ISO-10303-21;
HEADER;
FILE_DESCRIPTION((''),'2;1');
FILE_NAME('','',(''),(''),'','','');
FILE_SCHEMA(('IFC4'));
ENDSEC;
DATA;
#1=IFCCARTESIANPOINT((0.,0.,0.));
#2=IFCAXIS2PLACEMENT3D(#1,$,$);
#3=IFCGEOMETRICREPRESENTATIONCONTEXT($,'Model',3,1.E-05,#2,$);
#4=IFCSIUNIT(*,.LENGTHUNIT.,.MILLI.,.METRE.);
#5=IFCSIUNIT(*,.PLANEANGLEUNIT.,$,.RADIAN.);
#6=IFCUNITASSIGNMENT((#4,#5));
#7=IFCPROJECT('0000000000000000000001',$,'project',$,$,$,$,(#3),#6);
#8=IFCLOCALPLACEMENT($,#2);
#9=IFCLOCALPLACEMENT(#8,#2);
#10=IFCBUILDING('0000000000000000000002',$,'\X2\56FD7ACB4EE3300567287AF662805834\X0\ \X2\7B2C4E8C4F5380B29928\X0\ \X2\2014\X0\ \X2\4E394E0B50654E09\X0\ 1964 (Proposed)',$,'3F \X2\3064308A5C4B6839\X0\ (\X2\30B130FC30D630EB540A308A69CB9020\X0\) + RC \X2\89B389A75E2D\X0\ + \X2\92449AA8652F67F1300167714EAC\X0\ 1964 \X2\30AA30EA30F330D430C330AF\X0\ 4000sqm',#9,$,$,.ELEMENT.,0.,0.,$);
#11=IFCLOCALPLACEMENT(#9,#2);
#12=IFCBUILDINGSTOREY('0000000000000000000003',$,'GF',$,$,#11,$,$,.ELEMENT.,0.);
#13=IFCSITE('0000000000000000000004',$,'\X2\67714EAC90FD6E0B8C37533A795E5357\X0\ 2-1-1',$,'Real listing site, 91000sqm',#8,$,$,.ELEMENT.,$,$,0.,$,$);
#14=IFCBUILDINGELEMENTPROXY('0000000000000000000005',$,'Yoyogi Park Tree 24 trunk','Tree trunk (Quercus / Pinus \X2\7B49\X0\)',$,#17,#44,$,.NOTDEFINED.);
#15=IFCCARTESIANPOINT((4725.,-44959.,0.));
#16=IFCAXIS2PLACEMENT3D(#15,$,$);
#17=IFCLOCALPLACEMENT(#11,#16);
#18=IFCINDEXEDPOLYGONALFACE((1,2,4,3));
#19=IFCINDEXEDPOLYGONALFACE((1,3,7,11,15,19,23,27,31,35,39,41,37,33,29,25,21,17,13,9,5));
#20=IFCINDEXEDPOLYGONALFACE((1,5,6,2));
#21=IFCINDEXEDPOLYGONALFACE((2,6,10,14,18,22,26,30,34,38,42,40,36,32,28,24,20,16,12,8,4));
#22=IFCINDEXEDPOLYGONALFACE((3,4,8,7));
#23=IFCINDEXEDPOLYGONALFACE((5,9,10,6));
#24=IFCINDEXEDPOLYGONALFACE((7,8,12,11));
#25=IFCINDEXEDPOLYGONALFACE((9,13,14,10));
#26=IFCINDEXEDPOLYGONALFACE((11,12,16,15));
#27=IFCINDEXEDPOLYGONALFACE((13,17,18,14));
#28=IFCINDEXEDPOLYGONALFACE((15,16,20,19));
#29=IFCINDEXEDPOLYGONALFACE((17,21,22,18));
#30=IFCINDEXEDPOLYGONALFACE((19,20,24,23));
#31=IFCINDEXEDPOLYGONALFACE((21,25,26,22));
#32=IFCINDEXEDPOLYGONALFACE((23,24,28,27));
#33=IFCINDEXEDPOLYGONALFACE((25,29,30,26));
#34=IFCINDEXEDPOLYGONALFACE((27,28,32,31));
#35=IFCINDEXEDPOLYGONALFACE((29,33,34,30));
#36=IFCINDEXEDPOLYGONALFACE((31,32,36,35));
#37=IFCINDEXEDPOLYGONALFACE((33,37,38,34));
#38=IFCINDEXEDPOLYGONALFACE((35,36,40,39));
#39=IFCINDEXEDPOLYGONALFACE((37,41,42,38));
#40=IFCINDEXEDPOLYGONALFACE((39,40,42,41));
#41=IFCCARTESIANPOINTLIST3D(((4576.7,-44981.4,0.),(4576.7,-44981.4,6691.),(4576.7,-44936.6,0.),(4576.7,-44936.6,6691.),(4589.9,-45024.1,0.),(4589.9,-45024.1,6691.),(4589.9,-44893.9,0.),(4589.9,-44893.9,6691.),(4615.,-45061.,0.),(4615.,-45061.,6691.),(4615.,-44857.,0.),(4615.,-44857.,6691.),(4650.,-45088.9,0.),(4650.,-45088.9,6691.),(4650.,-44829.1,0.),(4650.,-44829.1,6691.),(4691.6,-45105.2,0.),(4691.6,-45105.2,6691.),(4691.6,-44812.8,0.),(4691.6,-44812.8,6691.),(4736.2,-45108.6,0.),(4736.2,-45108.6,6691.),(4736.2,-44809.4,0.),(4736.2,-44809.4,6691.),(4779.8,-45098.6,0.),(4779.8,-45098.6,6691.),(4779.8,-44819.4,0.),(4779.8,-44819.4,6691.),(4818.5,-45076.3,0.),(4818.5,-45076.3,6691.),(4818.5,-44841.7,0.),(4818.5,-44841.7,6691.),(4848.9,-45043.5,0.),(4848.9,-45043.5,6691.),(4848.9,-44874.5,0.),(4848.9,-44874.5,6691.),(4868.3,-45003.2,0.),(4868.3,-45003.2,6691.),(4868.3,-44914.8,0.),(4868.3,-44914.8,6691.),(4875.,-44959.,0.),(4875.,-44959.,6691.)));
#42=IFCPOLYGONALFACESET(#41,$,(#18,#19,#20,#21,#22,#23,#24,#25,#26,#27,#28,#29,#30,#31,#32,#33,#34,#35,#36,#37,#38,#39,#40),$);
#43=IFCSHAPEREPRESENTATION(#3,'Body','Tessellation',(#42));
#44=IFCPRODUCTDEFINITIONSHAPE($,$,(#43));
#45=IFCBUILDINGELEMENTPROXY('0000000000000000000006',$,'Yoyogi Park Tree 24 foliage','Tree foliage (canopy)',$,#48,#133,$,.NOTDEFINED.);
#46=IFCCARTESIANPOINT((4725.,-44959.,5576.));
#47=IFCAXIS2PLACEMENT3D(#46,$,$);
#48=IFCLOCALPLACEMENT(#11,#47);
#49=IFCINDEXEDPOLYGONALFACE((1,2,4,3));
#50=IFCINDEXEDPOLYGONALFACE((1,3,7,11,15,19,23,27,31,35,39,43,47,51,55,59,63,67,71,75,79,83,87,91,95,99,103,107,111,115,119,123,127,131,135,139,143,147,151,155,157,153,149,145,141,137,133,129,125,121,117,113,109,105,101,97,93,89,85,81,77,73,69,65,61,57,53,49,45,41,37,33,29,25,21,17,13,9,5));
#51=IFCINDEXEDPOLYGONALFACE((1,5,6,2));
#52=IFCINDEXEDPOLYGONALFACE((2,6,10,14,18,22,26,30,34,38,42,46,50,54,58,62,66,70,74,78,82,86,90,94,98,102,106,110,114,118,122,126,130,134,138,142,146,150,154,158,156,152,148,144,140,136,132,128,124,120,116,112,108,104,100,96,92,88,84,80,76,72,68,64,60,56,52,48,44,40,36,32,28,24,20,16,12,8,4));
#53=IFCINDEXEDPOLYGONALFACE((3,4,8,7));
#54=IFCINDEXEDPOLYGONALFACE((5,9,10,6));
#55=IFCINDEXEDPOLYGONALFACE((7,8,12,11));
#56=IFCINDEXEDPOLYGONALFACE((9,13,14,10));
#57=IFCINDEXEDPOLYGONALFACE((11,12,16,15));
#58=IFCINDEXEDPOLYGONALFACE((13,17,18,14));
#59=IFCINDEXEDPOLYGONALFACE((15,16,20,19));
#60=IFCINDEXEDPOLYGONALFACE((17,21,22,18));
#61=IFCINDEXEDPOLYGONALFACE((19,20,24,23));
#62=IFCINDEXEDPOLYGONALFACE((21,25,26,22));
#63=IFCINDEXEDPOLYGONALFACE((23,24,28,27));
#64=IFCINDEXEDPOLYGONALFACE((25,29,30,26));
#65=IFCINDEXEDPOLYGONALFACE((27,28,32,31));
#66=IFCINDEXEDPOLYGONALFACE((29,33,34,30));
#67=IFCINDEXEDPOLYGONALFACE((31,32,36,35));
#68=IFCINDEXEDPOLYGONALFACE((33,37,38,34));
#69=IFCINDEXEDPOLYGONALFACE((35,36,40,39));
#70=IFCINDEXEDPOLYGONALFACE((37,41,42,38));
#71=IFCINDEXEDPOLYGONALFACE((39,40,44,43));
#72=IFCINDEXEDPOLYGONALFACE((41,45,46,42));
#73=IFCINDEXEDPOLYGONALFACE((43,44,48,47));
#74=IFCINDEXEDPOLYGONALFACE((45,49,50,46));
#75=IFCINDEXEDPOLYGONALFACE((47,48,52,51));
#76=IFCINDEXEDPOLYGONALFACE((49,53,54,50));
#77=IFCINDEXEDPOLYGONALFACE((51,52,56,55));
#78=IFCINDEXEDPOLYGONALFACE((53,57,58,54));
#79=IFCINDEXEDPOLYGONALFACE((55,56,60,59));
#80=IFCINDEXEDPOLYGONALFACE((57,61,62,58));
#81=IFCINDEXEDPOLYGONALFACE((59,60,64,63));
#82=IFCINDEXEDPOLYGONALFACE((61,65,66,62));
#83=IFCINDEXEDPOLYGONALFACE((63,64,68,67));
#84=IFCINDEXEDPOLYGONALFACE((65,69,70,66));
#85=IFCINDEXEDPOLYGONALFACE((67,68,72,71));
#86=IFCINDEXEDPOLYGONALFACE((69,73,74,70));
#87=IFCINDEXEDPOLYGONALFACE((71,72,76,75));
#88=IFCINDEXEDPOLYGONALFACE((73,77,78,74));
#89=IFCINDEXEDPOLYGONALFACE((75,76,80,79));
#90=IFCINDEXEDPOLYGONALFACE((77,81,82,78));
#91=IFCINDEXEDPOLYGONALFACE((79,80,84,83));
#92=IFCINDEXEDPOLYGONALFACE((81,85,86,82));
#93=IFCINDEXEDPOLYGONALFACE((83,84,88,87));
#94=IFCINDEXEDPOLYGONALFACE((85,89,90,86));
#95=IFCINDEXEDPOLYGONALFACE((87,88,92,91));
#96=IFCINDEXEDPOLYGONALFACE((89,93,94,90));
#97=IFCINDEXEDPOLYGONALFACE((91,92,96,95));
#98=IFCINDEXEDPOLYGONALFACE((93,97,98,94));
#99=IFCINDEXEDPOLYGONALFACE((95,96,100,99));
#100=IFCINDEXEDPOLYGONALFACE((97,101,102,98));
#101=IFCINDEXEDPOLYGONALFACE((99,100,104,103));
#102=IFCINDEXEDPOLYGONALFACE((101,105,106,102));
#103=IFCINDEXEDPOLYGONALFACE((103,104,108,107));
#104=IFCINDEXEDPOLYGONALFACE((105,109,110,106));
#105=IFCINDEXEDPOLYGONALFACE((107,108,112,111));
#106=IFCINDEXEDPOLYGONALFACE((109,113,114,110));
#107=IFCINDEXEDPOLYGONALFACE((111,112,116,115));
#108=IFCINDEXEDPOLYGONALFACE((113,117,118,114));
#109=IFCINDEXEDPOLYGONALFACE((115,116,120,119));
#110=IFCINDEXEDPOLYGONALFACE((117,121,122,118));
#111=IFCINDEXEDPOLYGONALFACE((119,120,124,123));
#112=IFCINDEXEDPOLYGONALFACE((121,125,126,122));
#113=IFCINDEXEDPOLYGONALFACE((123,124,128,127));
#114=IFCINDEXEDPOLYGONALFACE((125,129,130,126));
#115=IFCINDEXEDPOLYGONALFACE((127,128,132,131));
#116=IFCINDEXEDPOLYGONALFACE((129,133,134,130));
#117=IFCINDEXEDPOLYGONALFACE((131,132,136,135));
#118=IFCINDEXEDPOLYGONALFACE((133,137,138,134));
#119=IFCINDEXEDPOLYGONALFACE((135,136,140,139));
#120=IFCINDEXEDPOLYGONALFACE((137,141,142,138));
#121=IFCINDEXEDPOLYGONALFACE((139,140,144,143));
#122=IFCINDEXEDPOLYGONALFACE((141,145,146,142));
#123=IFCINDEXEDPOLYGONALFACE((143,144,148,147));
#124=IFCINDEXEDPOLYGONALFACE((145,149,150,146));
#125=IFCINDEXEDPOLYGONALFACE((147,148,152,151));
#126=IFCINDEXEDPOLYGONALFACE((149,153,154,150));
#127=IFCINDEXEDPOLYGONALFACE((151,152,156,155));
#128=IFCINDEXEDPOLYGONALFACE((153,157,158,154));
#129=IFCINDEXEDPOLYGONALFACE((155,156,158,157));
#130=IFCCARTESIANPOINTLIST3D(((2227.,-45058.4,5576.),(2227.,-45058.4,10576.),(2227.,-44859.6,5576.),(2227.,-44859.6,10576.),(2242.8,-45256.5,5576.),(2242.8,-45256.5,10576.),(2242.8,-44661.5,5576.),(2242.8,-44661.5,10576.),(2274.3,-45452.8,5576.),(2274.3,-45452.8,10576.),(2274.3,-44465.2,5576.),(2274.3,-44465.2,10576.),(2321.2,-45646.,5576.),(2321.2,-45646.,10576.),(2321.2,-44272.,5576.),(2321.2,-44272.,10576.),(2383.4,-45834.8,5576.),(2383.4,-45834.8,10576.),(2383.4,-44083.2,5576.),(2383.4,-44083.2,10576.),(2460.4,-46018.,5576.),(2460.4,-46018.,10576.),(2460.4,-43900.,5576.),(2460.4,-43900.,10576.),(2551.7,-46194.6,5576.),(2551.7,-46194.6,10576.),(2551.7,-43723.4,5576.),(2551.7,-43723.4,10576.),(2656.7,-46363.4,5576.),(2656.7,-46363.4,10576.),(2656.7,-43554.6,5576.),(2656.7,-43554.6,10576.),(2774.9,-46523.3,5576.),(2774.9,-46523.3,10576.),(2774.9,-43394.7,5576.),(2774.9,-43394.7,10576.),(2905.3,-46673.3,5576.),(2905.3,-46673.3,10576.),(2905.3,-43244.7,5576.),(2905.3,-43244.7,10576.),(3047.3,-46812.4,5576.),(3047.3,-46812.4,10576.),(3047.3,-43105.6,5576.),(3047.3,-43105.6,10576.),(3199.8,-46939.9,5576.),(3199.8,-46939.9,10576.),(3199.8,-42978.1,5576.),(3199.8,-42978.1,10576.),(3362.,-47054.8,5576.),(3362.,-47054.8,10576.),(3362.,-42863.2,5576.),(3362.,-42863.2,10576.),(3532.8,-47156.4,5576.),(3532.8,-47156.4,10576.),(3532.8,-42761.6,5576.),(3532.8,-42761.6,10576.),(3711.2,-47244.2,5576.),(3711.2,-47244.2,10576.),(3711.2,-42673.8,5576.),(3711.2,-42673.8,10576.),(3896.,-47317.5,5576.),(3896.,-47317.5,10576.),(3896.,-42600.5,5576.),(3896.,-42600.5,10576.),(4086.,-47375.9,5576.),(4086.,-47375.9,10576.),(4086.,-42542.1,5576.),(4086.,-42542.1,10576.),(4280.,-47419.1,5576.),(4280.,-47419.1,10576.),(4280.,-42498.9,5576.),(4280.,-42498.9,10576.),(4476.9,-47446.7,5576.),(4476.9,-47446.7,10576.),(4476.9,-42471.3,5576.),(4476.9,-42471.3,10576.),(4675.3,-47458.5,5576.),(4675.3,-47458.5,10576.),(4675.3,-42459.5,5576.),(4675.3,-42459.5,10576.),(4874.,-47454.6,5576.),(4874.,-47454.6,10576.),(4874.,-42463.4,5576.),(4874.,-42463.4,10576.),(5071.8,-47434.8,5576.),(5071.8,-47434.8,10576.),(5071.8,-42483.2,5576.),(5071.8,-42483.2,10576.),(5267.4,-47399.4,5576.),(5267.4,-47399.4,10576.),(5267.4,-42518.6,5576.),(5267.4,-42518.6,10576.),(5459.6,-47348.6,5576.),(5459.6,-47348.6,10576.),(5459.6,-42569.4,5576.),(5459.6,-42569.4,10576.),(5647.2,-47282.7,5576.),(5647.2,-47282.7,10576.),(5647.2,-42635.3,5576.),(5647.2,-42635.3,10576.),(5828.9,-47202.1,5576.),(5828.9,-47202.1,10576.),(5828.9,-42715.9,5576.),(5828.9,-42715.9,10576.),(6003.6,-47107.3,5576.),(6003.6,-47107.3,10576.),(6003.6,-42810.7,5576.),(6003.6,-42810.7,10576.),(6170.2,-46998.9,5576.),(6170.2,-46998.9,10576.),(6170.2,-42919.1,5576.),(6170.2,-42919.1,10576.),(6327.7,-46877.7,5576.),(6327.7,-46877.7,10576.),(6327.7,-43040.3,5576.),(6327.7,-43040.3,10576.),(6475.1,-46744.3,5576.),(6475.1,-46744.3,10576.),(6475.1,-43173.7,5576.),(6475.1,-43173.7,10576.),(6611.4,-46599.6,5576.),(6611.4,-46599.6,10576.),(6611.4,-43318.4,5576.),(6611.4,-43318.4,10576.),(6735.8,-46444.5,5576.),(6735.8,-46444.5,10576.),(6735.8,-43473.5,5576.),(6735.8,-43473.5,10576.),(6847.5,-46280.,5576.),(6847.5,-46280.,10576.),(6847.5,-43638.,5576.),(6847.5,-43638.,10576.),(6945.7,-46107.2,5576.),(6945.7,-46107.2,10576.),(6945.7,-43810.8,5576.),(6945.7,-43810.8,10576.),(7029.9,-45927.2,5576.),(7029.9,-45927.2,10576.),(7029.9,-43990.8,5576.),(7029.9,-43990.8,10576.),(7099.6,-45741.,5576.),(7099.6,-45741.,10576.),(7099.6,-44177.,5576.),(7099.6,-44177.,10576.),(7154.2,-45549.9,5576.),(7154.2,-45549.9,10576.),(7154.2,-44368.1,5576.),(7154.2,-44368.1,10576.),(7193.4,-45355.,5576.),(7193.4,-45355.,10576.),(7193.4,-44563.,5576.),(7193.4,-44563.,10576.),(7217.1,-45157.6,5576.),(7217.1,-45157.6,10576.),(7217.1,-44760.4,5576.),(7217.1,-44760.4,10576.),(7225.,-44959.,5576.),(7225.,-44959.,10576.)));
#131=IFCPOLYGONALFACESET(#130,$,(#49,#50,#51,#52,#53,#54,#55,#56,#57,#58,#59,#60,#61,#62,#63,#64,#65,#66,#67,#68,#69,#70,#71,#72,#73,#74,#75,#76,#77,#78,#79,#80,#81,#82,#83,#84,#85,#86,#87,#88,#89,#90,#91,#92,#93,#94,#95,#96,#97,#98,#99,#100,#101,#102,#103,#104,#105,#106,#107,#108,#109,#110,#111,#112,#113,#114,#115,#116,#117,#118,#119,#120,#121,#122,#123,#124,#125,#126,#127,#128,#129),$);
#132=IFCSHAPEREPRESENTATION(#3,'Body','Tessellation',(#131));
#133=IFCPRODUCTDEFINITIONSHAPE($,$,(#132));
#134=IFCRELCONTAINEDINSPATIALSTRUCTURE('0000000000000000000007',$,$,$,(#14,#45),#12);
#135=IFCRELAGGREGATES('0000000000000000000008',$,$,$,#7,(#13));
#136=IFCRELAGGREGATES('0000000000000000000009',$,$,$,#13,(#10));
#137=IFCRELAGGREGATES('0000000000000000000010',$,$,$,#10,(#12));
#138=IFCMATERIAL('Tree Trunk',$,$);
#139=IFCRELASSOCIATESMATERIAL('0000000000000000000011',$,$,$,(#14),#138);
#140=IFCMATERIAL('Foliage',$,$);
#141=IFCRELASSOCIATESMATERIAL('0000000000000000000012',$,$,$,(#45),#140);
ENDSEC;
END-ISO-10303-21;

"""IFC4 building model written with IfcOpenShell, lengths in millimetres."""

from ifc_helpers import new_model, si_unit, frame, origin, origin_2d, place, context, project, spatial, circle, extrude, material, element, save


model = new_model("IFC4")

# Units and contexts
model_context = context("Model", 3, precision=1e-05, world=origin())
ifc_project = project(units=[si_unit("LENGTHUNIT", "METRE", prefix="MILLI"), si_unit("PLANEANGLEUNIT", "RADIAN")], contexts=[model_context])

# Site, building, storey
site_placement = place(None, origin())
site = spatial("IfcSite", under=ifc_project, at=site_placement, Name="東京都渋谷区神南 2-1-1", ObjectType="Real listing site, 91000sqm", CompositionType="ELEMENT", RefElevation=0.0)
building_placement = place(site_placement, origin())
building = spatial("IfcBuilding", under=site, at=building_placement, Name="国立代々木競技場 第二体育館 — 丹下健三 1964 (Proposed)", ObjectType="3F つり屋根 (ケーブル吊り構造) + RC 観覧席 + 鉄骨支柱、東京 1964 オリンピック 4000sqm", CompositionType="ELEMENT", ElevationOfRefHeight=0.0, ElevationOfTerrain=0.0)
storey_placement = place(building_placement, origin())
storey = spatial("IfcBuildingStorey", under=building, at=storey_placement, Name="GF", CompositionType="ELEMENT", Elevation=0.0)

# Building element proxies
ifc_material_1 = material(Name="Tree Trunk")
ifc_material_2 = material(Name="Foliage")
proxy_1_placement = place(storey_placement, frame((4725.0, -44959.0, 0.0)))
element("IfcBuildingElementProxy", 1, at=proxy_1_placement, inside=storey, material=ifc_material_1, Name="Yoyogi Park Tree 24 trunk", Description="Tree trunk (Quercus / Pinus 等)", PredefinedType="NOTDEFINED", context=model_context, shape_type="SweptSolid", body=[
    extrude(circle(Radius=150.0, at=origin_2d()), frame((4725.0, -44959.0, 0.0)), (0.0, 0.0, 1.0), 6691.0),
])
proxy_2_placement = place(storey_placement, frame((4725.0, -44959.0, 5576.0)))
element("IfcBuildingElementProxy", 2, at=proxy_2_placement, inside=storey, material=ifc_material_2, Name="Yoyogi Park Tree 24 foliage", Description="Tree foliage (canopy)", PredefinedType="NOTDEFINED", context=model_context, shape_type="SweptSolid", body=[
    extrude(circle(Radius=2500.0, at=origin_2d()), frame((4725.0, -44959.0, 5576.0)), (0.0, 0.0, 1.0), 5000.0),
])

save(model, "model.ifc")
